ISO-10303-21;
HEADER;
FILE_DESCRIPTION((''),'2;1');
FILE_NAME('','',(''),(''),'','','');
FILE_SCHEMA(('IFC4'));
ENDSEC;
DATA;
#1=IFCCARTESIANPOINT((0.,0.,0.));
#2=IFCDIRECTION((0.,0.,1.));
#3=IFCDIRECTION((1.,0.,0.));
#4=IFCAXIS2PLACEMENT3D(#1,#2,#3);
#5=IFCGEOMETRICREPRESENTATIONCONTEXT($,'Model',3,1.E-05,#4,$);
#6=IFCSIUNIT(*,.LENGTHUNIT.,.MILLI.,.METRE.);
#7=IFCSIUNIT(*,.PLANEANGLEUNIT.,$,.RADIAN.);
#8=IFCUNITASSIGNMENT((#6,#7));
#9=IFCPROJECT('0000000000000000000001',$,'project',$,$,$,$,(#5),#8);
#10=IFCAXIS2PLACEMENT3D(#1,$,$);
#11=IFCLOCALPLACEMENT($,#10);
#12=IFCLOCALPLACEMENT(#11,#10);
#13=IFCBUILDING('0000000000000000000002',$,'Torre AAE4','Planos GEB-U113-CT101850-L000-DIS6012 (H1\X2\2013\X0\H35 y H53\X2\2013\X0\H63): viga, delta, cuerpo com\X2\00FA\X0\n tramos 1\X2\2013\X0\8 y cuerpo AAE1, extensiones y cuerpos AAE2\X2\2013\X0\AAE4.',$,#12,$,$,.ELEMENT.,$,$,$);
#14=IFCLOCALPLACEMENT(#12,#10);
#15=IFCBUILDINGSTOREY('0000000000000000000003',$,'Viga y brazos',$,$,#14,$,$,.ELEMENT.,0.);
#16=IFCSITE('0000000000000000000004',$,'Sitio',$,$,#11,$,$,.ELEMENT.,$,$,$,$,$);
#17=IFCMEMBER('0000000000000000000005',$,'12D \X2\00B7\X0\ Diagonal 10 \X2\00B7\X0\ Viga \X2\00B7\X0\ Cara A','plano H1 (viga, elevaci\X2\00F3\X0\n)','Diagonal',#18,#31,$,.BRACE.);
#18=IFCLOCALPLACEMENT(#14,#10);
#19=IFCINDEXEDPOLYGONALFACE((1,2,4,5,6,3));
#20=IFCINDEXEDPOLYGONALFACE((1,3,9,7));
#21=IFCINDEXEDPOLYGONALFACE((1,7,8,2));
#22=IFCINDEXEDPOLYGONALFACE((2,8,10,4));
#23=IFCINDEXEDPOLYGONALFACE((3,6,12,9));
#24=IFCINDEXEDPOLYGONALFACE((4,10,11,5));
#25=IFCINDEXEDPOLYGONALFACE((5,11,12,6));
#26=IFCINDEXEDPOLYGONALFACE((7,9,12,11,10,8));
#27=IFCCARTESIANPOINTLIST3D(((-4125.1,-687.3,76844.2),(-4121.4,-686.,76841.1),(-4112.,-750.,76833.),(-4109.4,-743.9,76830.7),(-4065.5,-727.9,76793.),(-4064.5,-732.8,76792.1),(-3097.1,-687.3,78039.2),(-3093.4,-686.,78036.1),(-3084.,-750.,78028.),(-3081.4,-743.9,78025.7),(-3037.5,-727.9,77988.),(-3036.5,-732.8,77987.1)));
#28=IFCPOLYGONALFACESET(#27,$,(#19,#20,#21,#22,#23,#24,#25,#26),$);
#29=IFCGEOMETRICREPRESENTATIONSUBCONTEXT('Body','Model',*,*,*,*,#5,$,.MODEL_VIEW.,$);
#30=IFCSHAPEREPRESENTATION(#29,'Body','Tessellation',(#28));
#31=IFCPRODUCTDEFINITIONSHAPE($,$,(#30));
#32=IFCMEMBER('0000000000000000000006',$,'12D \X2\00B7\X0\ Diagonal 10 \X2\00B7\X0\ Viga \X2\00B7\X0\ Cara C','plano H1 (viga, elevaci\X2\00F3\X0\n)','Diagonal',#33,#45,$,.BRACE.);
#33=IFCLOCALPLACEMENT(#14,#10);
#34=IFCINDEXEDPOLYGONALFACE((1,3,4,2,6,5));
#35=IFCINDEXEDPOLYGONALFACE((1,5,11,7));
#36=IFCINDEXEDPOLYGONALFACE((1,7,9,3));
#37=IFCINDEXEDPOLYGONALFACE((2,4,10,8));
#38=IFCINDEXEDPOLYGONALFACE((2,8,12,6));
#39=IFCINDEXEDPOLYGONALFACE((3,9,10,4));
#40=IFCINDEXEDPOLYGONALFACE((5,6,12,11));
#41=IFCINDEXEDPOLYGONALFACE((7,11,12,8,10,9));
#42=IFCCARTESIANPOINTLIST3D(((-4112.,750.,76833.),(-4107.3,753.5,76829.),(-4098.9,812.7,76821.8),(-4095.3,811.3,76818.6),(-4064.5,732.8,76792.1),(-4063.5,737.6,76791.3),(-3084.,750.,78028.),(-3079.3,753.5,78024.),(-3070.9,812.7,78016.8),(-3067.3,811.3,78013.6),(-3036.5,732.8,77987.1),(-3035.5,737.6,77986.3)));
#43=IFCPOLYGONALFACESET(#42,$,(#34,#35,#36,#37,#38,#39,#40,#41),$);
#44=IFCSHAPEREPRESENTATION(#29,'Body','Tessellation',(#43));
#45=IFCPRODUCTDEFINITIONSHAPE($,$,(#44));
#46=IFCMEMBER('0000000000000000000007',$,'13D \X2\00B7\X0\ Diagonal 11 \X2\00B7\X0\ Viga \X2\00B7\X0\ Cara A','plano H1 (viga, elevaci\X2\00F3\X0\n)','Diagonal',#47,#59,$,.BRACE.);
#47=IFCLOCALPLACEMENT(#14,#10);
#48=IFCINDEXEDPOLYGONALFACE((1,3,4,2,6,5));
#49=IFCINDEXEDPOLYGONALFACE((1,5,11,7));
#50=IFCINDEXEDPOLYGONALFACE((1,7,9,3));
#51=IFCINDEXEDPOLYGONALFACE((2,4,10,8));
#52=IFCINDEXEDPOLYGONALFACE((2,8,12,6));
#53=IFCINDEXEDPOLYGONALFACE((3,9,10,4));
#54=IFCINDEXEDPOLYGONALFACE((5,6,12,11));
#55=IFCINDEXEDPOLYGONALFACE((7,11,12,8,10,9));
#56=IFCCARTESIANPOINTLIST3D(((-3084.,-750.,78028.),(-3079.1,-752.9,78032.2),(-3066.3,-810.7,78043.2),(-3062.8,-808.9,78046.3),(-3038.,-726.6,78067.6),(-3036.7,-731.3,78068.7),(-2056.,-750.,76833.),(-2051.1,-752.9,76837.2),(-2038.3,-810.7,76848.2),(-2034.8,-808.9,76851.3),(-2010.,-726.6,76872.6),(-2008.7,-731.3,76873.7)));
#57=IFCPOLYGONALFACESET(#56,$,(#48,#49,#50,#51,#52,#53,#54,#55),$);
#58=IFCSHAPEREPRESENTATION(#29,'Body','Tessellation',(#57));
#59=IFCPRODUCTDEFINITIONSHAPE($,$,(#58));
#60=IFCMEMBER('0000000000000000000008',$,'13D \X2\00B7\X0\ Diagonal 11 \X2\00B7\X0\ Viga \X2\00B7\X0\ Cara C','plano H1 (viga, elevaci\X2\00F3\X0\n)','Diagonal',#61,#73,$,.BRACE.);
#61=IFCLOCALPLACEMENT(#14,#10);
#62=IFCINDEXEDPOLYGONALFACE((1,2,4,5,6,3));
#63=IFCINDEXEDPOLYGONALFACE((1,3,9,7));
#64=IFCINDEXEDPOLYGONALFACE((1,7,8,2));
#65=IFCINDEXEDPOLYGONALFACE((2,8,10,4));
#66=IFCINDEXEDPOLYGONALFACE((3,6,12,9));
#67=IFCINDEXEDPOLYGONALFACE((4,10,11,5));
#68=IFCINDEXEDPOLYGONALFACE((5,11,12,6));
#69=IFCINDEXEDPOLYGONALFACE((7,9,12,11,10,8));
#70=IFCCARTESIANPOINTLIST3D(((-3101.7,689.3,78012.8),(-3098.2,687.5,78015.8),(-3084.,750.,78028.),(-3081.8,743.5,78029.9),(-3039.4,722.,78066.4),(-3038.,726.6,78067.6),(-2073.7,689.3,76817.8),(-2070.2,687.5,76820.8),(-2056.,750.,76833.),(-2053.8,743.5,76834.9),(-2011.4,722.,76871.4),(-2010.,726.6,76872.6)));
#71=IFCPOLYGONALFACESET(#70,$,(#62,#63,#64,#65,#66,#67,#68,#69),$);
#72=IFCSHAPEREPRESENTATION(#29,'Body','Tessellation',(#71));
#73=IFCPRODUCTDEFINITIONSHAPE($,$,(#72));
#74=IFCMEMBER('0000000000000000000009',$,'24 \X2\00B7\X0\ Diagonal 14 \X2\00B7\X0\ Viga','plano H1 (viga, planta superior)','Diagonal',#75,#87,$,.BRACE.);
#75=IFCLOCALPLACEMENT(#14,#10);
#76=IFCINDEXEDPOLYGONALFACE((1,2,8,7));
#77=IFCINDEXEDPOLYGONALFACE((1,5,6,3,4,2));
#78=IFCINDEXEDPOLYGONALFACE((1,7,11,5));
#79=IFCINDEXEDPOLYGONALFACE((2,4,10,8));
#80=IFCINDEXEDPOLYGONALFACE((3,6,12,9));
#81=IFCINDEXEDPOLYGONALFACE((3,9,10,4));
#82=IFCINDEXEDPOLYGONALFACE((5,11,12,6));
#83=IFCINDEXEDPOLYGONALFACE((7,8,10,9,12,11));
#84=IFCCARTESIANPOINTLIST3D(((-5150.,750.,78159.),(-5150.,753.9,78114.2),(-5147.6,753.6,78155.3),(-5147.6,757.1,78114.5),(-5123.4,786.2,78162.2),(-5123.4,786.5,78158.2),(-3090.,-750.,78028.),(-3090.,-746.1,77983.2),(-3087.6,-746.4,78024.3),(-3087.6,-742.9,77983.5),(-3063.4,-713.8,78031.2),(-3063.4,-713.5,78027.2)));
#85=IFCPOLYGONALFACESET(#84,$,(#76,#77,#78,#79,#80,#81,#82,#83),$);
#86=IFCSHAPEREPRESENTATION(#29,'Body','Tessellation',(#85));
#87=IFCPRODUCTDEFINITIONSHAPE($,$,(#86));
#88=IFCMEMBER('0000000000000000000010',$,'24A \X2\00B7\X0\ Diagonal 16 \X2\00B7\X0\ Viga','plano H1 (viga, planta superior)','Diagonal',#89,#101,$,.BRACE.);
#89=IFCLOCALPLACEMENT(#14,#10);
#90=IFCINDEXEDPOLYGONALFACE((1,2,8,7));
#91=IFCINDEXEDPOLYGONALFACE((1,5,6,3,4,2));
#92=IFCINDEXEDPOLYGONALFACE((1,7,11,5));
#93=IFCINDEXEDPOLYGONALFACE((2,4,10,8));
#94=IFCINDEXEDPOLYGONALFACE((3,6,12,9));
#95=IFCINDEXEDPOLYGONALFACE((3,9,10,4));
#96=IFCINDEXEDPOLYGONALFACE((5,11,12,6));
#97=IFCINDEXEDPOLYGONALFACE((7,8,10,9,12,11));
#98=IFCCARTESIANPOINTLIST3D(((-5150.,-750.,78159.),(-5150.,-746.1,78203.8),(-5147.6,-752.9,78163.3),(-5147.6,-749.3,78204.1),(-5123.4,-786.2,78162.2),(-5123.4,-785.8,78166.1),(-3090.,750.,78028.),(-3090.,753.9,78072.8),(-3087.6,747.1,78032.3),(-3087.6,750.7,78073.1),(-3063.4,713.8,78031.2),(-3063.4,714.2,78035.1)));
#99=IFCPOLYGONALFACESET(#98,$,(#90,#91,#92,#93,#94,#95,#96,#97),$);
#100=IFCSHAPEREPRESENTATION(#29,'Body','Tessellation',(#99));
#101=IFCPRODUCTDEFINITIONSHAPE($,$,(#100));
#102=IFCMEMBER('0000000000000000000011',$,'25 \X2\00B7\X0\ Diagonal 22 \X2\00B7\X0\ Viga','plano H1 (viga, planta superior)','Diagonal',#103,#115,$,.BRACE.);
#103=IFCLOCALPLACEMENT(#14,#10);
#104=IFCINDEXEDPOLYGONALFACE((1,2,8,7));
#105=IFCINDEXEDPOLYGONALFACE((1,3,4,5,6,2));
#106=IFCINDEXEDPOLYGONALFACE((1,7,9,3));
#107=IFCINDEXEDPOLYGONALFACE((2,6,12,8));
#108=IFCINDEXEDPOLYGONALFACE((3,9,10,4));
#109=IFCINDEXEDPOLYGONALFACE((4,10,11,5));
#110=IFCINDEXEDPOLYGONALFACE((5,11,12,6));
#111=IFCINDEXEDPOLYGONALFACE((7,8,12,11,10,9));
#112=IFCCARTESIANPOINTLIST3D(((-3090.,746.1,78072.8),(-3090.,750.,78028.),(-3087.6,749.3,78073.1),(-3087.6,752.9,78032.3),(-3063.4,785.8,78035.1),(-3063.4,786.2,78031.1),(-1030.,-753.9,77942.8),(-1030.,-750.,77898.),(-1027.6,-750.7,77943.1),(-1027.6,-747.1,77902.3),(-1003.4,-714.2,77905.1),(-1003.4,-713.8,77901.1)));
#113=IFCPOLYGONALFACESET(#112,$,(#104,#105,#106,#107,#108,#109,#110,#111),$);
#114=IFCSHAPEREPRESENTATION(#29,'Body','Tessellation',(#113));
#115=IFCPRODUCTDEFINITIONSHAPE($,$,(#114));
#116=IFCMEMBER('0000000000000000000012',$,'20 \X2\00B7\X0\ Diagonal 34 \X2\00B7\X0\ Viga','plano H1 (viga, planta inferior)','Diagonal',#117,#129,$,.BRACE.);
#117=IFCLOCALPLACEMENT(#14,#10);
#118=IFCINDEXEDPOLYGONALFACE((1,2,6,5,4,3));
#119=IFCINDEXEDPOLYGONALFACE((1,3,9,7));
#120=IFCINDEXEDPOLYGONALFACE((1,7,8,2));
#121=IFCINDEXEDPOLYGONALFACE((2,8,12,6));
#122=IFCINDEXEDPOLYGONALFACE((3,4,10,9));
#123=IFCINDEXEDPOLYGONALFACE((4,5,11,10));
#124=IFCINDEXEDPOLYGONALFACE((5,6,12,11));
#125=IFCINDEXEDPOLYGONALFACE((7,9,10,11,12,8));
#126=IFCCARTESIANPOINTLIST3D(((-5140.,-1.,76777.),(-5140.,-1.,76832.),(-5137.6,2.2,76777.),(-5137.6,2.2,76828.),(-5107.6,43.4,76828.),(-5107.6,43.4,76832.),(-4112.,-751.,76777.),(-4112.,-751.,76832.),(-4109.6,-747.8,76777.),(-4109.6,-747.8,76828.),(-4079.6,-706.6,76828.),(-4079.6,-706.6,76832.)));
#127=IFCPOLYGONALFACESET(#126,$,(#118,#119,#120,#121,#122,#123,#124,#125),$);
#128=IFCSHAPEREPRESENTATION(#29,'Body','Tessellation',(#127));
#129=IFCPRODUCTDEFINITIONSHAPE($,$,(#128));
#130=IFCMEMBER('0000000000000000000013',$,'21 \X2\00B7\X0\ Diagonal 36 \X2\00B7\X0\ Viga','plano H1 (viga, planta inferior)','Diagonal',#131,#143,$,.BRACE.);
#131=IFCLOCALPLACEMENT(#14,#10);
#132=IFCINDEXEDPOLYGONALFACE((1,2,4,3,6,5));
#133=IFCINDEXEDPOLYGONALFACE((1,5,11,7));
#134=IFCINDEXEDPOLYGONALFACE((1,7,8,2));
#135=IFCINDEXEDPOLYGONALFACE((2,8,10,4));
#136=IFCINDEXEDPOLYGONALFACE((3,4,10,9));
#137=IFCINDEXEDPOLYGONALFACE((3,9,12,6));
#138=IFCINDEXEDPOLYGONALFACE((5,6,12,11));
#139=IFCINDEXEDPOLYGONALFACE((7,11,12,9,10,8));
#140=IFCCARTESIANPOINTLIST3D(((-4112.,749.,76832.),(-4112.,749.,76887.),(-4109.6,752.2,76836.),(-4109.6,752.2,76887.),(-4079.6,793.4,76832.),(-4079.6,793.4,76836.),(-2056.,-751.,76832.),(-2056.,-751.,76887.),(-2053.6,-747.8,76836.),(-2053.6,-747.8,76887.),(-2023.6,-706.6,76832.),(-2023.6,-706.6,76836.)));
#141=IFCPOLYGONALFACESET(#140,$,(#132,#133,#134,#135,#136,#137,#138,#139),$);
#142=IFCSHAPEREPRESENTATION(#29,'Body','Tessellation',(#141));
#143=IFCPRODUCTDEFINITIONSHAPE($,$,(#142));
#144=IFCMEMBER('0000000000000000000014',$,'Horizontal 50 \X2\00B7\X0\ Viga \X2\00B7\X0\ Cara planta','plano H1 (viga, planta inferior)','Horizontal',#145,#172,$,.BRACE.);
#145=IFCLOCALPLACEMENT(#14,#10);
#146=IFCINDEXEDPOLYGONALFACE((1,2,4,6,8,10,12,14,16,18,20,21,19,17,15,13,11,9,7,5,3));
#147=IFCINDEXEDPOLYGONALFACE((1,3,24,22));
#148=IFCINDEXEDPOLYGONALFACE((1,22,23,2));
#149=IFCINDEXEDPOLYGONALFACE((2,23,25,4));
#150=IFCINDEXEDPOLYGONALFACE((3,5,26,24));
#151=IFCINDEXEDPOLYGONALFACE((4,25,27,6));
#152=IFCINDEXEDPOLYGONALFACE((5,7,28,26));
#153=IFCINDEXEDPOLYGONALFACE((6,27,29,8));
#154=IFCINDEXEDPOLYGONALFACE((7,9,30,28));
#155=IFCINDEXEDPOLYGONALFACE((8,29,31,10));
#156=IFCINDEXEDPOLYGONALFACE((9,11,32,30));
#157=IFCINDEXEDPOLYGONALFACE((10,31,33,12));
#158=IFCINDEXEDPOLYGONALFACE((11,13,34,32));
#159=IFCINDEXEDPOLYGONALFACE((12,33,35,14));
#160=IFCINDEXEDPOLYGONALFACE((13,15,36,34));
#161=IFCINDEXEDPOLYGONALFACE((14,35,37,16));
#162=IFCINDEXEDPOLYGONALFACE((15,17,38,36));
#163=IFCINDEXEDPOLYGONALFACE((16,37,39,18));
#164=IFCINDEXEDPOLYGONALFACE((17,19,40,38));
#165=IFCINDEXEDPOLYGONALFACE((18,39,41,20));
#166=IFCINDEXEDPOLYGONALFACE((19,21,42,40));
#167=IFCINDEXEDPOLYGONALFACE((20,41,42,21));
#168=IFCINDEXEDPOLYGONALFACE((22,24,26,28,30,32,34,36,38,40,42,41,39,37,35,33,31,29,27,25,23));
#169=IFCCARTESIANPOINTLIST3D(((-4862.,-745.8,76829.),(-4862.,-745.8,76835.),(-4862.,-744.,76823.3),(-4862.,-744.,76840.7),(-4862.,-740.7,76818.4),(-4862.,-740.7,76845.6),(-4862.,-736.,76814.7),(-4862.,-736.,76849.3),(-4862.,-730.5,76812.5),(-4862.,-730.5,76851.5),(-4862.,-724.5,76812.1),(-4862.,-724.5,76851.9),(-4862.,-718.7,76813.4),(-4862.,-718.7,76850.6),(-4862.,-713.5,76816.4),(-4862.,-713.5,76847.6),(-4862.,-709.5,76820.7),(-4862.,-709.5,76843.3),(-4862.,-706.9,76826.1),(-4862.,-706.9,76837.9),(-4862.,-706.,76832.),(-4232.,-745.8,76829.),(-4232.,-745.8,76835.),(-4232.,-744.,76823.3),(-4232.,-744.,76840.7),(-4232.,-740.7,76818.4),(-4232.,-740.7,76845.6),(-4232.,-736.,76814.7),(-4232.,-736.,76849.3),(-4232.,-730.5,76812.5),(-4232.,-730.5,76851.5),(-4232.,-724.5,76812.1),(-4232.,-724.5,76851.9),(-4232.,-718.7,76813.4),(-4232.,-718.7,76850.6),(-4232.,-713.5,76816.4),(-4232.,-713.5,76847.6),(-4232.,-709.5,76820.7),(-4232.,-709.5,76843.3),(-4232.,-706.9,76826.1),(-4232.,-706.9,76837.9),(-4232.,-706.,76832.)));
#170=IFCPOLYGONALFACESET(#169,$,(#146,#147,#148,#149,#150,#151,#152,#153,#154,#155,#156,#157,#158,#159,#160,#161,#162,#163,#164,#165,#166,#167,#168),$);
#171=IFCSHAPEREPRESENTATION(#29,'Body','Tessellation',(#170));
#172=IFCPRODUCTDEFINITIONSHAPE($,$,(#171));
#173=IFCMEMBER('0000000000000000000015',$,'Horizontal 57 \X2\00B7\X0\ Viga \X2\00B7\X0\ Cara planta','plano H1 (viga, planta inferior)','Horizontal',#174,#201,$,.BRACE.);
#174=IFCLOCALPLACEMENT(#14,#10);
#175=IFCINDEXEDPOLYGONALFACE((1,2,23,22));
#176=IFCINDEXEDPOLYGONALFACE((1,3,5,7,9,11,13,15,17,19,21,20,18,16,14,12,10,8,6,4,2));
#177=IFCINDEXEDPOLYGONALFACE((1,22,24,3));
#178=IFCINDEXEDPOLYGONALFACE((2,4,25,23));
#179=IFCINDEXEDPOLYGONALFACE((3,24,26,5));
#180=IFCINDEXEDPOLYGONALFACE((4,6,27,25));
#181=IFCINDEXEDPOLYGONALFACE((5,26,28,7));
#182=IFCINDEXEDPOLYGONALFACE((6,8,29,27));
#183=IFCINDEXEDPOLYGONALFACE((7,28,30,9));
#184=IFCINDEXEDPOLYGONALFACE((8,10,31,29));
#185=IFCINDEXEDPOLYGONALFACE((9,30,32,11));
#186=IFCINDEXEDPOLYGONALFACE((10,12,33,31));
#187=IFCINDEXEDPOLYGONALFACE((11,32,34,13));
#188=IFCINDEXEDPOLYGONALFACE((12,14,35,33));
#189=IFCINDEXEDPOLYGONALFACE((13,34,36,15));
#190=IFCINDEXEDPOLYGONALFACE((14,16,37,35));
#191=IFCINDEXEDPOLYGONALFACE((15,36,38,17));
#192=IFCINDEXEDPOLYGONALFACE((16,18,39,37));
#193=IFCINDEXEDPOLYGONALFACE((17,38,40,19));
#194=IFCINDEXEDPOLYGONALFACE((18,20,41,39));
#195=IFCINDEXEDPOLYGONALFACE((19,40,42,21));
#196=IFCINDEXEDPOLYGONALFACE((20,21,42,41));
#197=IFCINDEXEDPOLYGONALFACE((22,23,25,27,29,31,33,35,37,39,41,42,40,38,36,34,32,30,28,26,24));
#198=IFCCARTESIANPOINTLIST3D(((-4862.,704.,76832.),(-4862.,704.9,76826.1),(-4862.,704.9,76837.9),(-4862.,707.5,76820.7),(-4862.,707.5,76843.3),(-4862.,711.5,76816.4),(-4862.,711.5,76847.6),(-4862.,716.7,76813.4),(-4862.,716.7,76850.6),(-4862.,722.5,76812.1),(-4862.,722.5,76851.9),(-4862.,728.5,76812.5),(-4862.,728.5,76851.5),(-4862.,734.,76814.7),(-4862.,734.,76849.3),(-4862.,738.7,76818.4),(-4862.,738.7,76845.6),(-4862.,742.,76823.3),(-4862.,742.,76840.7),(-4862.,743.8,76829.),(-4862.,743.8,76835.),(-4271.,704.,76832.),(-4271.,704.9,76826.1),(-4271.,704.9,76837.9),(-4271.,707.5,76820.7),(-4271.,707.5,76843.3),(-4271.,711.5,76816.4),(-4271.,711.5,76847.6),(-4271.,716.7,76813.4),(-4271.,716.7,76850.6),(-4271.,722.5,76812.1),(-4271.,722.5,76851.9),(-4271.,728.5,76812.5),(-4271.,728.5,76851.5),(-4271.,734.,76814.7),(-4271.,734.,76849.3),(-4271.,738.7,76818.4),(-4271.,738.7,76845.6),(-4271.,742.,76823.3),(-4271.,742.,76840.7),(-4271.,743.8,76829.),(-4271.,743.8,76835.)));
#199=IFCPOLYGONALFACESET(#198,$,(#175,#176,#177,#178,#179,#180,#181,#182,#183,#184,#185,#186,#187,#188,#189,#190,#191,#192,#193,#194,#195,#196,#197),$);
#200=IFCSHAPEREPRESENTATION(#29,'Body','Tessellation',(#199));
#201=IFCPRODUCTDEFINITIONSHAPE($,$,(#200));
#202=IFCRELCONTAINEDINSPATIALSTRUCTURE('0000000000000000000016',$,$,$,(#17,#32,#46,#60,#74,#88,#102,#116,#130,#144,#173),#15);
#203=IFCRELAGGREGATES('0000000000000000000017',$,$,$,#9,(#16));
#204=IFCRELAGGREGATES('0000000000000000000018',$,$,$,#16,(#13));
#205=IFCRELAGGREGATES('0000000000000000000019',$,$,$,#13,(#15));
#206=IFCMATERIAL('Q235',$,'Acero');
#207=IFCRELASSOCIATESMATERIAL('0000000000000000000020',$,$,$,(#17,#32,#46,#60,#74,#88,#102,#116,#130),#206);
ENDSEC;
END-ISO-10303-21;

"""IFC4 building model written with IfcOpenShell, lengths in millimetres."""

from ifc_helpers import new_model, si_unit, frame, frame_2d, origin, origin_with_axes, place, context, subcontext, project, spatial, circle, l_section, extrude, material, element, save


model = new_model("IFC4")

# Units and contexts
model_context = context("Model", 3, precision=1e-05, world=origin_with_axes())
body_context = subcontext(model_context, "Body", "Model", "MODEL_VIEW")
ifc_project = project(units=[si_unit("LENGTHUNIT", "METRE", prefix="MILLI"), si_unit("PLANEANGLEUNIT", "RADIAN")], contexts=[model_context])

# Site, building, storey
site_placement = place(None, origin())
site = spatial("IfcSite", under=ifc_project, at=site_placement, Name="Sitio", CompositionType="ELEMENT")
building_placement = place(site_placement, origin())
building = spatial("IfcBuilding", under=site, at=building_placement, Name="Torre AAE4", Description="Planos GEB-U113-CT101850-L000-DIS6012 (H1–H35 y H53–H63): viga, delta, cuerpo común tramos 1–8 y cuerpo AAE1, extensiones y cuerpos AAE2–AAE4.", CompositionType="ELEMENT")
storey_placement = place(building_placement, origin())
storey = spatial("IfcBuildingStorey", under=building, at=storey_placement, Name="Viga y brazos", CompositionType="ELEMENT", Elevation=0.0)

# Members
ifc_material = material(Name="Q235", Category="Acero")
for number, where, z_axis, x_axis, name in (
    (1, (-4112.0, -750.0, 76833.0), (0.652149, 0.0, 0.758091), (0.730962, 0.265126, -0.628811), "12D · Diagonal 10 · Viga · Cara A"),
    (2, (-4112.0, 750.0, 76833.0), (0.652149, 0.0, 0.758091), (0.730962, -0.265126, -0.628811), "12D · Diagonal 10 · Viga · Cara C"),
    (3, (-3084.0, -750.0, 78028.0), (0.652149, 0.0, -0.758091), (0.707481, 0.359253, 0.608611), "13D · Diagonal 11 · Viga · Cara A"),
    (4, (-3084.0, 750.0, 78028.0), (0.652149, 0.0, -0.758091), (0.707481, -0.359253, 0.608611), "13D · Diagonal 11 · Viga · Cara C"),
):
    element("IfcMember", number, at=place(storey_placement, frame(where, z_axis=z_axis, x_axis=x_axis)), inside=storey, material=ifc_material, Name=name, Description="plano H1 (viga, elevación)", ObjectType="Diagonal", PredefinedType="BRACE", context=body_context, shape_type="SweptSolid", body=[
        extrude(l_section(Depth=65.0, Width=65.0, Thickness=5.0, at=frame_2d((32.5, 32.5))), None, (0.0, 0.0, 1.0), 1576.3),
    ])
for number, where, z_axis, x_axis, name in (
    (5, (-3090.0, -750.0, 78028.0), (-0.80733, 0.587862, 0.05134), (0.5901, 0.804269, 0.07024), "24 · Diagonal 14 · Viga"),
    (6, (-3090.0, 750.0, 78028.0), (-0.80733, -0.587862, 0.05134), (0.5901, -0.804269, 0.07024), "24A · Diagonal 16 · Viga"),
):
    element("IfcMember", number, at=place(storey_placement, frame(where, z_axis=z_axis, x_axis=x_axis)), inside=storey, material=ifc_material, Name=name, Description="plano H1 (viga, planta superior)", ObjectType="Diagonal", PredefinedType="BRACE", context=body_context, shape_type="SweptSolid", body=[
        extrude(l_section(Depth=45.0, Width=45.0, Thickness=4.0, at=frame_2d((22.5, 22.5))), None, (0.0, 0.0, 1.0), 2551.6),
    ])
member_1_placement = place(storey_placement, frame((-3090.0, 750.0, 78028.0), z_axis=(0.807347, -0.587874, -0.050949), x_axis=(0.590077, 0.804332, 0.069709)))
element("IfcMember", 7, at=member_1_placement, inside=storey, material=ifc_material, Name="25 · Diagonal 22 · Viga", Description="plano H1 (viga, planta superior)", ObjectType="Diagonal", PredefinedType="BRACE", context=body_context, shape_type="SweptSolid", body=[
    extrude(l_section(Depth=45.0, Width=45.0, Thickness=4.0, at=frame_2d((22.5, 22.5))), None, (0.0, 0.0, 1.0), 2551.6),
])
member_2_placement = place(storey_placement, frame((-4112.0, -751.0, 76832.0), z_axis=(-0.807852, 0.589386, 0.0), x_axis=(0.589386, 0.807852, 0.0)))
element("IfcMember", 8, at=member_2_placement, inside=storey, material=ifc_material, Name="20 · Diagonal 34 · Viga", Description="plano H1 (viga, planta inferior)", ObjectType="Diagonal", PredefinedType="BRACE", context=body_context, shape_type="SweptSolid", body=[
    extrude(l_section(Depth=55.0, Width=55.0, Thickness=4.0, at=frame_2d((27.5, 27.5))), None, (0.0, 0.0, 1.0), 1272.5),
])
member_3_placement = place(storey_placement, frame((-4112.0, 749.0, 76832.0), z_axis=(0.807852, -0.589386, 0.0), x_axis=(0.589386, 0.807852, 0.0)))
element("IfcMember", 9, at=member_3_placement, inside=storey, material=ifc_material, Name="21 · Diagonal 36 · Viga", Description="plano H1 (viga, planta inferior)", ObjectType="Diagonal", PredefinedType="BRACE", context=body_context, shape_type="SweptSolid", body=[
    extrude(l_section(Depth=55.0, Width=55.0, Thickness=4.0, at=frame_2d((27.5, 27.5))), None, (0.0, 0.0, 1.0), 2545.0),
])
member_4_placement = place(storey_placement, frame((-4232.0, -726.0, 76832.0), z_axis=(-1.0, 0.0, 0.0), x_axis=(0.0, 1.0, 0.0)))
element("IfcMember", 10, at=member_4_placement, inside=storey, Name="Horizontal 50 · Viga · Cara planta", Description="plano H1 (viga, planta inferior)", ObjectType="Horizontal", PredefinedType="BRACE", context=body_context, shape_type="SweptSolid", body=[
    extrude(circle(Radius=20.0), None, (0.0, 0.0, 1.0), 630.0),
])
member_5_placement = place(storey_placement, frame((-4271.0, 724.0, 76832.0), z_axis=(-1.0, 0.0, 0.0), x_axis=(0.0, -1.0, 0.0)))
element("IfcMember", 11, at=member_5_placement, inside=storey, Name="Horizontal 57 · Viga · Cara planta", Description="plano H1 (viga, planta inferior)", ObjectType="Horizontal", PredefinedType="BRACE", context=body_context, shape_type="SweptSolid", body=[
    extrude(circle(Radius=20.0), None, (0.0, 0.0, 1.0), 591.0),
])

save(model, "model.ifc")
